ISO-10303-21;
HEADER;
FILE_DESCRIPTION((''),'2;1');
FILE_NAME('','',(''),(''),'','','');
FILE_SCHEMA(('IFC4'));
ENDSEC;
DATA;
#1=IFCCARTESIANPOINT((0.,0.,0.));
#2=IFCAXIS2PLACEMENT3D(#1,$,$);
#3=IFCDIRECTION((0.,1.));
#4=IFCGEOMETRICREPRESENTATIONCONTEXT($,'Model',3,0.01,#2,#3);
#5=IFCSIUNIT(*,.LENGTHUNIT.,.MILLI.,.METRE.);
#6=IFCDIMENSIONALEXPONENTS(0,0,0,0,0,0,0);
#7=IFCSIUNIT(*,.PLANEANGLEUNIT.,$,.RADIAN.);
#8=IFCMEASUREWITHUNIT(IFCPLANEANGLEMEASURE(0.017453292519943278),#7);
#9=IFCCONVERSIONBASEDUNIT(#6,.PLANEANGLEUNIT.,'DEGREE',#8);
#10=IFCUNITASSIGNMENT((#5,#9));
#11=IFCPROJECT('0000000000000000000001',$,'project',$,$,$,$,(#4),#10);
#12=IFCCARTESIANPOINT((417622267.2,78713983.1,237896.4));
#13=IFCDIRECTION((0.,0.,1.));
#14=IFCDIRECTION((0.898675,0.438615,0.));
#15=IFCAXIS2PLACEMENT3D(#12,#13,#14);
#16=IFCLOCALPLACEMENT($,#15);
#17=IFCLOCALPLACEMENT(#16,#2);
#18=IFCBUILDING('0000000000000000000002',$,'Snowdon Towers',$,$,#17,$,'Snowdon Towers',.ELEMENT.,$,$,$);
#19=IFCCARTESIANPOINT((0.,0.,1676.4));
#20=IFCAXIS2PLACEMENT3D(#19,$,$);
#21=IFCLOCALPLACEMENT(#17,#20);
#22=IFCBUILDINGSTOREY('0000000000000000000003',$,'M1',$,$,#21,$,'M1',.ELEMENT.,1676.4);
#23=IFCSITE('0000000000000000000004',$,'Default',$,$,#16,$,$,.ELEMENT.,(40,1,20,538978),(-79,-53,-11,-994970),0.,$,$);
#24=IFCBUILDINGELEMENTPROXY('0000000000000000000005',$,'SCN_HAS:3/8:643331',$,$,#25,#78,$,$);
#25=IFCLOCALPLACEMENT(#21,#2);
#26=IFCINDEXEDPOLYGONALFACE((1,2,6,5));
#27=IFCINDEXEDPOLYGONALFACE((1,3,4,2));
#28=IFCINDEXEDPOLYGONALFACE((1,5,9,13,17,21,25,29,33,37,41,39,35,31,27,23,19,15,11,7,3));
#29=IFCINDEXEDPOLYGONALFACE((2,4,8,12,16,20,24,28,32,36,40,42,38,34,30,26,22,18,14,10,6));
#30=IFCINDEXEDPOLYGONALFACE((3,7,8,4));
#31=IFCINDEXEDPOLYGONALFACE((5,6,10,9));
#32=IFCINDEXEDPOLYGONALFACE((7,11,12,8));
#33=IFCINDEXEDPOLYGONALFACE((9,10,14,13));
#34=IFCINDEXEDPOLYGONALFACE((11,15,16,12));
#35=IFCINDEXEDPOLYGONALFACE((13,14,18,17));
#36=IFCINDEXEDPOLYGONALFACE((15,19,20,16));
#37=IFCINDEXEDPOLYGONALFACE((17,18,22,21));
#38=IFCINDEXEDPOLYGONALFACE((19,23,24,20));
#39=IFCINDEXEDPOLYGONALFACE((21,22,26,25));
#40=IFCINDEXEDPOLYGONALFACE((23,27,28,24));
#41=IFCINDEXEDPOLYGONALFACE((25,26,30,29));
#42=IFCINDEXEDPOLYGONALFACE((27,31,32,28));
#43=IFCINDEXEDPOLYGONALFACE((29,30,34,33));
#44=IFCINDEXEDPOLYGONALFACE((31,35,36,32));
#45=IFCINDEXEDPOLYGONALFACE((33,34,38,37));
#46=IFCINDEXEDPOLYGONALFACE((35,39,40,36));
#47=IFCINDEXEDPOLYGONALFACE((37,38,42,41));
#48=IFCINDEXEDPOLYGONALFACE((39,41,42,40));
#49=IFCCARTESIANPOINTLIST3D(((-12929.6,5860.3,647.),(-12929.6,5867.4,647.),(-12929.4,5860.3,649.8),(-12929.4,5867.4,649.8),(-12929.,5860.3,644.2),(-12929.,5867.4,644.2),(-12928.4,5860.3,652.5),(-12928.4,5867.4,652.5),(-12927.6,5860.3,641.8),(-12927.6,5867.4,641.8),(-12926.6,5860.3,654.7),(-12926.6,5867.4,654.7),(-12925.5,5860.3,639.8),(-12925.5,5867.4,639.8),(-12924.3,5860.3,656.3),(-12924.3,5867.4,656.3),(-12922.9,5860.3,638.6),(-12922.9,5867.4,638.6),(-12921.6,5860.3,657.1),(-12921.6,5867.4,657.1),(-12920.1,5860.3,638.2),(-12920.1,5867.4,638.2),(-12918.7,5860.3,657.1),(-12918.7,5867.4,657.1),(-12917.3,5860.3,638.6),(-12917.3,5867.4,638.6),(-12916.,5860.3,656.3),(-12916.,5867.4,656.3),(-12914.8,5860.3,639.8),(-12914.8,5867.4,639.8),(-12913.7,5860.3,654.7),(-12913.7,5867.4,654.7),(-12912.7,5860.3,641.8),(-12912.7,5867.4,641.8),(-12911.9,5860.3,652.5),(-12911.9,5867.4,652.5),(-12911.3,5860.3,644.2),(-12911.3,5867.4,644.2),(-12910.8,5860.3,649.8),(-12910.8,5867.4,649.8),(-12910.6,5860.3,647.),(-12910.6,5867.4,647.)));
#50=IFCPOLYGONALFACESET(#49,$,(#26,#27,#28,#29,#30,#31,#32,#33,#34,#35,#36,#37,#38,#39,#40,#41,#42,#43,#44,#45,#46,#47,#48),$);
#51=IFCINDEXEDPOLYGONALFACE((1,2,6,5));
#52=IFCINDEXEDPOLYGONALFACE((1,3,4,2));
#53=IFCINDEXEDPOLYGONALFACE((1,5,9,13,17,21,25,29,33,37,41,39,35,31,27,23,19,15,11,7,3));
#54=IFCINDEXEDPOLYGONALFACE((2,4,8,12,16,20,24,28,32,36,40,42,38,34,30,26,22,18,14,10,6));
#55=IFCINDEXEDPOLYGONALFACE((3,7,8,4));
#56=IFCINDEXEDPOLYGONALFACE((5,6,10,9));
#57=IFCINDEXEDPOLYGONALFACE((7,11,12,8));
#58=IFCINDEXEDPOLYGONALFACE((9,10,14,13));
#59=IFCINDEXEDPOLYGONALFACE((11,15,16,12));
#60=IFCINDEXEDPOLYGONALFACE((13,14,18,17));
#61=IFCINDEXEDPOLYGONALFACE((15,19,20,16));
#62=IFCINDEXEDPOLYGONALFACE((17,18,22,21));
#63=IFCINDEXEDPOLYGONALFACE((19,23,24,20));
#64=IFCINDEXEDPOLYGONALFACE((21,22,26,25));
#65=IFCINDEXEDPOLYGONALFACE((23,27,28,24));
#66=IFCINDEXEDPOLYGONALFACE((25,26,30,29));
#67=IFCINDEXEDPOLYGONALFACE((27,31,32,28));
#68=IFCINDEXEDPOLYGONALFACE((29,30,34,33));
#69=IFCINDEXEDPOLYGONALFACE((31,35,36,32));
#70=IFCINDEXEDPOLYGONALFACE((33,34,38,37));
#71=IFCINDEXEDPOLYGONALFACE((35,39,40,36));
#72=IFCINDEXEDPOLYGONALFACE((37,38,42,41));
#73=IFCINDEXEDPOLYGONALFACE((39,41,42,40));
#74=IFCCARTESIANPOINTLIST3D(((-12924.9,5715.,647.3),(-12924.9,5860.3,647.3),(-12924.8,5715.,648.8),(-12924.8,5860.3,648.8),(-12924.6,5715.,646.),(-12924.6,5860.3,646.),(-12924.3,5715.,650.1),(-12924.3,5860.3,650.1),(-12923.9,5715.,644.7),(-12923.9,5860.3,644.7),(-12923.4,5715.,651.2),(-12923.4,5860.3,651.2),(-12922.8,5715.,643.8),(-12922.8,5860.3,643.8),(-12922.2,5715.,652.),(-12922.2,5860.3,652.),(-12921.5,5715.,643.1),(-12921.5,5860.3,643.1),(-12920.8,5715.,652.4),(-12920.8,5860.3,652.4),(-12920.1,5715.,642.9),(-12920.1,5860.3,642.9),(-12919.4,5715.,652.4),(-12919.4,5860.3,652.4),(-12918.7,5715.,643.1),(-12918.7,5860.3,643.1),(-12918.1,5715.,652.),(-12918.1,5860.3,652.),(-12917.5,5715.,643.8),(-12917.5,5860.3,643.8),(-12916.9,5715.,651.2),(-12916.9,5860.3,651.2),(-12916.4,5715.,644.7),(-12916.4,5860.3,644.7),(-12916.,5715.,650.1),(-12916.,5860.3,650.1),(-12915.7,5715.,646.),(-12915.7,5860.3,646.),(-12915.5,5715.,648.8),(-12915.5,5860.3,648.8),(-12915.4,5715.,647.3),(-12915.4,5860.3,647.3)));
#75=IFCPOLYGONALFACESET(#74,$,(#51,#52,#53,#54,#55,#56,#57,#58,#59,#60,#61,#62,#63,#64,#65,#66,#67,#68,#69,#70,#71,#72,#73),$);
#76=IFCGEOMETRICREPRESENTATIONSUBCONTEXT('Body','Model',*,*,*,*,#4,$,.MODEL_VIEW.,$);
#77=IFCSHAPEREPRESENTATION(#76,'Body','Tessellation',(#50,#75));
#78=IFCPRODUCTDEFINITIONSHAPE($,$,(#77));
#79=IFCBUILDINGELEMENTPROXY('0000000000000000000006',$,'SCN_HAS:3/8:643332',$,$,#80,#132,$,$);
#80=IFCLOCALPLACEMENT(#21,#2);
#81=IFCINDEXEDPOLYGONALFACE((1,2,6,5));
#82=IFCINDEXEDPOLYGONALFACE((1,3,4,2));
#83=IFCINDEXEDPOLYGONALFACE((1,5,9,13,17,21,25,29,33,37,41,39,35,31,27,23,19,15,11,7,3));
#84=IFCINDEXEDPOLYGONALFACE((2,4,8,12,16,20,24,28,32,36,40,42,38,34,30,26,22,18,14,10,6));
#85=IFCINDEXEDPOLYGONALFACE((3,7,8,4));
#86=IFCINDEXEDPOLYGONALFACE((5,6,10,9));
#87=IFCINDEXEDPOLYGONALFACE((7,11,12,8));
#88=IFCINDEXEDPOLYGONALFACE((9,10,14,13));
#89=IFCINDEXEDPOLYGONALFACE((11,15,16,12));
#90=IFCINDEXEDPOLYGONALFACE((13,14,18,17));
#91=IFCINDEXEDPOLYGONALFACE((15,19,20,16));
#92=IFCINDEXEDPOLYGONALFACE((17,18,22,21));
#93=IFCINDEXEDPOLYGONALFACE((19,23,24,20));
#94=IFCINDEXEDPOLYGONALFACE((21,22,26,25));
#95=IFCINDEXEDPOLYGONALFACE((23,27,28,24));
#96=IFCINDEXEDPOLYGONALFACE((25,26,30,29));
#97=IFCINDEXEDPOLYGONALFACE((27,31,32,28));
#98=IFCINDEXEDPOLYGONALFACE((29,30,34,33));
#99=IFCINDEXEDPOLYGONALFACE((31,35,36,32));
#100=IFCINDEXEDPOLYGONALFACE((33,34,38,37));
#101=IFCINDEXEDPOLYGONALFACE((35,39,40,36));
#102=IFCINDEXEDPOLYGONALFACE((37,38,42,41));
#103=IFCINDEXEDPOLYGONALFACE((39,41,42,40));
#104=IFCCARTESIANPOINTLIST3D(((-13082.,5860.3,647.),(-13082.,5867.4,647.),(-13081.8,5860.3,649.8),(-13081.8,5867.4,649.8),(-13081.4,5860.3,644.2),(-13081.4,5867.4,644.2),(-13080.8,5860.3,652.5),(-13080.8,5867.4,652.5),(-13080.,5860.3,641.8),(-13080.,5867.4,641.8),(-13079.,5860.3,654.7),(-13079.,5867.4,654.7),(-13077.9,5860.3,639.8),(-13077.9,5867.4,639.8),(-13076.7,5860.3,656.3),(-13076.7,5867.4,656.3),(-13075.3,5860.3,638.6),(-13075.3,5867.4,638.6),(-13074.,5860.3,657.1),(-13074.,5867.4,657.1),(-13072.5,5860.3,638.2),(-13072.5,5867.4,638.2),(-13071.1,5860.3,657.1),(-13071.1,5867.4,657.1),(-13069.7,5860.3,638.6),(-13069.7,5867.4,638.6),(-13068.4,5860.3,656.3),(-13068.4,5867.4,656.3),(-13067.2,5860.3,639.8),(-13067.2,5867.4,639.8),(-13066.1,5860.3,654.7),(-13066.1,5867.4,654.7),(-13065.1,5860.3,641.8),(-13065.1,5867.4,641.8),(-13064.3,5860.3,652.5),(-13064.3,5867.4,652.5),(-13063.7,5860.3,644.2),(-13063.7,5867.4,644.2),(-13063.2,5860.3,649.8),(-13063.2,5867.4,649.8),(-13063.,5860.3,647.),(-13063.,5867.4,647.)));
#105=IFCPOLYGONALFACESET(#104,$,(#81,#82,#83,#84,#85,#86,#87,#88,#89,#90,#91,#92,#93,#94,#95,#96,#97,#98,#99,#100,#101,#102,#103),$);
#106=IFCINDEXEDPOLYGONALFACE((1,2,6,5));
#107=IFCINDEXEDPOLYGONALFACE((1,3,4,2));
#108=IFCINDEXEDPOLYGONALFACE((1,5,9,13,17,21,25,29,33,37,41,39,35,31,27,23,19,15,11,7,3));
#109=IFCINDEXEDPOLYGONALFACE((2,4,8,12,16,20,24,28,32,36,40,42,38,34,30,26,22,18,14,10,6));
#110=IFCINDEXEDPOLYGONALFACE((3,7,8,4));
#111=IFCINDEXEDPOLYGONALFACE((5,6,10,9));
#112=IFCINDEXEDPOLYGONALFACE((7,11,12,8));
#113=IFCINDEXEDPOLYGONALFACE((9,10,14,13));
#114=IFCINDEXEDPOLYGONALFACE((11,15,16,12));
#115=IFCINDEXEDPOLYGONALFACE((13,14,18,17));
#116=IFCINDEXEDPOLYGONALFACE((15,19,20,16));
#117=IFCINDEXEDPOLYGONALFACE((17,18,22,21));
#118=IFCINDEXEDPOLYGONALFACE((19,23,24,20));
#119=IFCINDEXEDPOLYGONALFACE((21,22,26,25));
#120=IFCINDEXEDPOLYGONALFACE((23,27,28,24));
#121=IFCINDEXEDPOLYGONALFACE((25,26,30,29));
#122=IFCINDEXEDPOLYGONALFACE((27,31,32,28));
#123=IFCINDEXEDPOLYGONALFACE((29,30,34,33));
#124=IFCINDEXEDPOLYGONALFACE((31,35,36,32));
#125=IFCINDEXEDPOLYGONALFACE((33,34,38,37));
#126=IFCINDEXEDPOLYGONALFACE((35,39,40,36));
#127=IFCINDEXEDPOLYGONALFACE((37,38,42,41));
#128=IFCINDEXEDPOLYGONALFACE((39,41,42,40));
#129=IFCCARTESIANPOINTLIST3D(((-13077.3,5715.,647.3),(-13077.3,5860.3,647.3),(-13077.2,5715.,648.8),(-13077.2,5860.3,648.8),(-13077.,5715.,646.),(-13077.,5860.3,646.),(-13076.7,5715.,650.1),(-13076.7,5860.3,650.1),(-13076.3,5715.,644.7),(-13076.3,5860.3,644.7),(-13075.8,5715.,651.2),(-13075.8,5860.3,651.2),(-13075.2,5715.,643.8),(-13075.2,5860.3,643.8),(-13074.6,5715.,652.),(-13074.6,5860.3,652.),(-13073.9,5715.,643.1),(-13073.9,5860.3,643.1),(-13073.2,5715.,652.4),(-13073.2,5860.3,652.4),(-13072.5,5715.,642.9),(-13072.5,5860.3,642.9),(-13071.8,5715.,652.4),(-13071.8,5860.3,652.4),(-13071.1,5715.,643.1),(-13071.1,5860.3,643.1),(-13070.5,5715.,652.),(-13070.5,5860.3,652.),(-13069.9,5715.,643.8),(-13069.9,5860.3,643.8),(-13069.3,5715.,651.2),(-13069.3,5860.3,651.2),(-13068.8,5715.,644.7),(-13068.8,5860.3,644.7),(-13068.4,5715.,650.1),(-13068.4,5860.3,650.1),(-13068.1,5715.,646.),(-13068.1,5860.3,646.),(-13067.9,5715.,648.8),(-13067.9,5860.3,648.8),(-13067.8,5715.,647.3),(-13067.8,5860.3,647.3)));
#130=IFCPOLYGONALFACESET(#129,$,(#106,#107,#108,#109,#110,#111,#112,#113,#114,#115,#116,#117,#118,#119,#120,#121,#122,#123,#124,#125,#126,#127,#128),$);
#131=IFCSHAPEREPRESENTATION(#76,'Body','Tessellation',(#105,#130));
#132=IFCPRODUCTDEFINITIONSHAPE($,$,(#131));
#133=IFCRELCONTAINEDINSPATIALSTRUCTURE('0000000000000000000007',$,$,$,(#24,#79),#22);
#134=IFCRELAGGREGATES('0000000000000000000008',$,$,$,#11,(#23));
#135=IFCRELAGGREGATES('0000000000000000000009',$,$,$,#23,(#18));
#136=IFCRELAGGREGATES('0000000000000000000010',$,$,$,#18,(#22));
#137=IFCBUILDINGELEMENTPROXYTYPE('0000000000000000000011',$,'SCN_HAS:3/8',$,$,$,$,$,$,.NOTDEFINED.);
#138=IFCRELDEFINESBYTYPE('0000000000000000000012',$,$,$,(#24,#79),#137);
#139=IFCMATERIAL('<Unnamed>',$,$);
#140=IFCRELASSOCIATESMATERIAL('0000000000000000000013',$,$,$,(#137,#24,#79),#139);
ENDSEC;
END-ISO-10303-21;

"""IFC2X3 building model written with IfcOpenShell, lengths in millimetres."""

from ifc_helpers import new_model, entity, si_unit, converted_unit, direction, frame, frame_2d, origin, place, context, subcontext, project, spatial, circle, extrude, source, transform, mapped, material, type_object, type_shapes, element, save


model = new_model("IFC2X3")

# Units and contexts
model_context = context("Model", 3, precision=0.01, world=origin(), true_north=direction((0.0, 1.0)))
body_context = subcontext(model_context, "Body", "Model", "MODEL_VIEW")
ifc_project = project(units=[si_unit("LENGTHUNIT", "METRE", prefix="MILLI"), converted_unit("PLANEANGLEUNIT", "DEGREE", entity("IfcPlaneAngleMeasure", 0.017453292519943278), si_unit("PLANEANGLEUNIT", "RADIAN"), dimensions=[0, 0, 0, 0, 0, 0, 0])], contexts=[model_context])

# Site, building, storey
site_placement = place(None, frame((417622267.2, 78713983.1, 237896.4), z_axis=(0.0, 0.0, 1.0), x_axis=(0.898675, 0.438615, 0.0)))
site = spatial("IfcSite", under=ifc_project, at=site_placement, Name="Default", CompositionType="ELEMENT", RefLatitude=(40, 1, 20, 538978), RefLongitude=(-79, -53, -11, -994970), RefElevation=0.0)
building_placement = place(site_placement, origin())
building = spatial("IfcBuilding", under=site, at=building_placement, Name="Snowdon Towers", LongName="Snowdon Towers", CompositionType="ELEMENT")
storey_placement = place(building_placement, frame((0.0, 0.0, 1676.4)))
storey = spatial("IfcBuildingStorey", under=building, at=storey_placement, Name="M1", LongName="M1", CompositionType="ELEMENT", Elevation=1676.4)

# Building element proxies
ifc_material_1 = material(Name="<Unnamed>")
building_element_proxy_type = type_object("IfcBuildingElementProxyType", Name="SCN_HAS:3/8", PredefinedType="NOTDEFINED", material=ifc_material_1)
shared_shape_1 = source(origin(), body_context, "Body", "SweptSolid", [
    extrude(circle(Radius=9.5, at=frame_2d((0.0, 0.0), x_axis=(1.0, 0.0))), frame((0.0, 0.0, -152.4), z_axis=(0.0, 0.0, 1.0), x_axis=(0.0, -1.0, 0.0)), (0.0, 0.0, 1.0), 7.1),
    extrude(circle(Radius=4.8, at=frame_2d((0.0, 0.0), x_axis=(1.0, 0.0))), frame((0.0, 0.0, -145.3), z_axis=(0.0, 0.0, 1.0), x_axis=(0.0, -1.0, 0.0)), (0.0, 0.0, 1.0), 145.3),
])
type_shapes(building_element_proxy_type, [shared_shape_1])
for number, where, z_axis, x_axis, name in (
    (1, (-12920.1, 5715.0, 647.7), (0.0, -1.0, 0.0), (1.0, 0.0, 0.0), "SCN_HAS:3/8:643331"),
    (2, (-13072.5, 5715.0, 647.7), (0.0, -1.0, 0.0), (1.0, 0.0, 0.0), "SCN_HAS:3/8:643332"),
):
    element("IfcBuildingElementProxy", number, at=place(storey_placement, frame(where, z_axis=z_axis, x_axis=x_axis)), inside=storey, type_object=building_element_proxy_type, material=ifc_material_1, Name=name, context=body_context, shape_type="MappedRepresentation", body=[
        mapped(shared_shape_1, transform((0.0, 0.0, 0.0), scale=1.0)),
    ])

save(model, "model.ifc")
